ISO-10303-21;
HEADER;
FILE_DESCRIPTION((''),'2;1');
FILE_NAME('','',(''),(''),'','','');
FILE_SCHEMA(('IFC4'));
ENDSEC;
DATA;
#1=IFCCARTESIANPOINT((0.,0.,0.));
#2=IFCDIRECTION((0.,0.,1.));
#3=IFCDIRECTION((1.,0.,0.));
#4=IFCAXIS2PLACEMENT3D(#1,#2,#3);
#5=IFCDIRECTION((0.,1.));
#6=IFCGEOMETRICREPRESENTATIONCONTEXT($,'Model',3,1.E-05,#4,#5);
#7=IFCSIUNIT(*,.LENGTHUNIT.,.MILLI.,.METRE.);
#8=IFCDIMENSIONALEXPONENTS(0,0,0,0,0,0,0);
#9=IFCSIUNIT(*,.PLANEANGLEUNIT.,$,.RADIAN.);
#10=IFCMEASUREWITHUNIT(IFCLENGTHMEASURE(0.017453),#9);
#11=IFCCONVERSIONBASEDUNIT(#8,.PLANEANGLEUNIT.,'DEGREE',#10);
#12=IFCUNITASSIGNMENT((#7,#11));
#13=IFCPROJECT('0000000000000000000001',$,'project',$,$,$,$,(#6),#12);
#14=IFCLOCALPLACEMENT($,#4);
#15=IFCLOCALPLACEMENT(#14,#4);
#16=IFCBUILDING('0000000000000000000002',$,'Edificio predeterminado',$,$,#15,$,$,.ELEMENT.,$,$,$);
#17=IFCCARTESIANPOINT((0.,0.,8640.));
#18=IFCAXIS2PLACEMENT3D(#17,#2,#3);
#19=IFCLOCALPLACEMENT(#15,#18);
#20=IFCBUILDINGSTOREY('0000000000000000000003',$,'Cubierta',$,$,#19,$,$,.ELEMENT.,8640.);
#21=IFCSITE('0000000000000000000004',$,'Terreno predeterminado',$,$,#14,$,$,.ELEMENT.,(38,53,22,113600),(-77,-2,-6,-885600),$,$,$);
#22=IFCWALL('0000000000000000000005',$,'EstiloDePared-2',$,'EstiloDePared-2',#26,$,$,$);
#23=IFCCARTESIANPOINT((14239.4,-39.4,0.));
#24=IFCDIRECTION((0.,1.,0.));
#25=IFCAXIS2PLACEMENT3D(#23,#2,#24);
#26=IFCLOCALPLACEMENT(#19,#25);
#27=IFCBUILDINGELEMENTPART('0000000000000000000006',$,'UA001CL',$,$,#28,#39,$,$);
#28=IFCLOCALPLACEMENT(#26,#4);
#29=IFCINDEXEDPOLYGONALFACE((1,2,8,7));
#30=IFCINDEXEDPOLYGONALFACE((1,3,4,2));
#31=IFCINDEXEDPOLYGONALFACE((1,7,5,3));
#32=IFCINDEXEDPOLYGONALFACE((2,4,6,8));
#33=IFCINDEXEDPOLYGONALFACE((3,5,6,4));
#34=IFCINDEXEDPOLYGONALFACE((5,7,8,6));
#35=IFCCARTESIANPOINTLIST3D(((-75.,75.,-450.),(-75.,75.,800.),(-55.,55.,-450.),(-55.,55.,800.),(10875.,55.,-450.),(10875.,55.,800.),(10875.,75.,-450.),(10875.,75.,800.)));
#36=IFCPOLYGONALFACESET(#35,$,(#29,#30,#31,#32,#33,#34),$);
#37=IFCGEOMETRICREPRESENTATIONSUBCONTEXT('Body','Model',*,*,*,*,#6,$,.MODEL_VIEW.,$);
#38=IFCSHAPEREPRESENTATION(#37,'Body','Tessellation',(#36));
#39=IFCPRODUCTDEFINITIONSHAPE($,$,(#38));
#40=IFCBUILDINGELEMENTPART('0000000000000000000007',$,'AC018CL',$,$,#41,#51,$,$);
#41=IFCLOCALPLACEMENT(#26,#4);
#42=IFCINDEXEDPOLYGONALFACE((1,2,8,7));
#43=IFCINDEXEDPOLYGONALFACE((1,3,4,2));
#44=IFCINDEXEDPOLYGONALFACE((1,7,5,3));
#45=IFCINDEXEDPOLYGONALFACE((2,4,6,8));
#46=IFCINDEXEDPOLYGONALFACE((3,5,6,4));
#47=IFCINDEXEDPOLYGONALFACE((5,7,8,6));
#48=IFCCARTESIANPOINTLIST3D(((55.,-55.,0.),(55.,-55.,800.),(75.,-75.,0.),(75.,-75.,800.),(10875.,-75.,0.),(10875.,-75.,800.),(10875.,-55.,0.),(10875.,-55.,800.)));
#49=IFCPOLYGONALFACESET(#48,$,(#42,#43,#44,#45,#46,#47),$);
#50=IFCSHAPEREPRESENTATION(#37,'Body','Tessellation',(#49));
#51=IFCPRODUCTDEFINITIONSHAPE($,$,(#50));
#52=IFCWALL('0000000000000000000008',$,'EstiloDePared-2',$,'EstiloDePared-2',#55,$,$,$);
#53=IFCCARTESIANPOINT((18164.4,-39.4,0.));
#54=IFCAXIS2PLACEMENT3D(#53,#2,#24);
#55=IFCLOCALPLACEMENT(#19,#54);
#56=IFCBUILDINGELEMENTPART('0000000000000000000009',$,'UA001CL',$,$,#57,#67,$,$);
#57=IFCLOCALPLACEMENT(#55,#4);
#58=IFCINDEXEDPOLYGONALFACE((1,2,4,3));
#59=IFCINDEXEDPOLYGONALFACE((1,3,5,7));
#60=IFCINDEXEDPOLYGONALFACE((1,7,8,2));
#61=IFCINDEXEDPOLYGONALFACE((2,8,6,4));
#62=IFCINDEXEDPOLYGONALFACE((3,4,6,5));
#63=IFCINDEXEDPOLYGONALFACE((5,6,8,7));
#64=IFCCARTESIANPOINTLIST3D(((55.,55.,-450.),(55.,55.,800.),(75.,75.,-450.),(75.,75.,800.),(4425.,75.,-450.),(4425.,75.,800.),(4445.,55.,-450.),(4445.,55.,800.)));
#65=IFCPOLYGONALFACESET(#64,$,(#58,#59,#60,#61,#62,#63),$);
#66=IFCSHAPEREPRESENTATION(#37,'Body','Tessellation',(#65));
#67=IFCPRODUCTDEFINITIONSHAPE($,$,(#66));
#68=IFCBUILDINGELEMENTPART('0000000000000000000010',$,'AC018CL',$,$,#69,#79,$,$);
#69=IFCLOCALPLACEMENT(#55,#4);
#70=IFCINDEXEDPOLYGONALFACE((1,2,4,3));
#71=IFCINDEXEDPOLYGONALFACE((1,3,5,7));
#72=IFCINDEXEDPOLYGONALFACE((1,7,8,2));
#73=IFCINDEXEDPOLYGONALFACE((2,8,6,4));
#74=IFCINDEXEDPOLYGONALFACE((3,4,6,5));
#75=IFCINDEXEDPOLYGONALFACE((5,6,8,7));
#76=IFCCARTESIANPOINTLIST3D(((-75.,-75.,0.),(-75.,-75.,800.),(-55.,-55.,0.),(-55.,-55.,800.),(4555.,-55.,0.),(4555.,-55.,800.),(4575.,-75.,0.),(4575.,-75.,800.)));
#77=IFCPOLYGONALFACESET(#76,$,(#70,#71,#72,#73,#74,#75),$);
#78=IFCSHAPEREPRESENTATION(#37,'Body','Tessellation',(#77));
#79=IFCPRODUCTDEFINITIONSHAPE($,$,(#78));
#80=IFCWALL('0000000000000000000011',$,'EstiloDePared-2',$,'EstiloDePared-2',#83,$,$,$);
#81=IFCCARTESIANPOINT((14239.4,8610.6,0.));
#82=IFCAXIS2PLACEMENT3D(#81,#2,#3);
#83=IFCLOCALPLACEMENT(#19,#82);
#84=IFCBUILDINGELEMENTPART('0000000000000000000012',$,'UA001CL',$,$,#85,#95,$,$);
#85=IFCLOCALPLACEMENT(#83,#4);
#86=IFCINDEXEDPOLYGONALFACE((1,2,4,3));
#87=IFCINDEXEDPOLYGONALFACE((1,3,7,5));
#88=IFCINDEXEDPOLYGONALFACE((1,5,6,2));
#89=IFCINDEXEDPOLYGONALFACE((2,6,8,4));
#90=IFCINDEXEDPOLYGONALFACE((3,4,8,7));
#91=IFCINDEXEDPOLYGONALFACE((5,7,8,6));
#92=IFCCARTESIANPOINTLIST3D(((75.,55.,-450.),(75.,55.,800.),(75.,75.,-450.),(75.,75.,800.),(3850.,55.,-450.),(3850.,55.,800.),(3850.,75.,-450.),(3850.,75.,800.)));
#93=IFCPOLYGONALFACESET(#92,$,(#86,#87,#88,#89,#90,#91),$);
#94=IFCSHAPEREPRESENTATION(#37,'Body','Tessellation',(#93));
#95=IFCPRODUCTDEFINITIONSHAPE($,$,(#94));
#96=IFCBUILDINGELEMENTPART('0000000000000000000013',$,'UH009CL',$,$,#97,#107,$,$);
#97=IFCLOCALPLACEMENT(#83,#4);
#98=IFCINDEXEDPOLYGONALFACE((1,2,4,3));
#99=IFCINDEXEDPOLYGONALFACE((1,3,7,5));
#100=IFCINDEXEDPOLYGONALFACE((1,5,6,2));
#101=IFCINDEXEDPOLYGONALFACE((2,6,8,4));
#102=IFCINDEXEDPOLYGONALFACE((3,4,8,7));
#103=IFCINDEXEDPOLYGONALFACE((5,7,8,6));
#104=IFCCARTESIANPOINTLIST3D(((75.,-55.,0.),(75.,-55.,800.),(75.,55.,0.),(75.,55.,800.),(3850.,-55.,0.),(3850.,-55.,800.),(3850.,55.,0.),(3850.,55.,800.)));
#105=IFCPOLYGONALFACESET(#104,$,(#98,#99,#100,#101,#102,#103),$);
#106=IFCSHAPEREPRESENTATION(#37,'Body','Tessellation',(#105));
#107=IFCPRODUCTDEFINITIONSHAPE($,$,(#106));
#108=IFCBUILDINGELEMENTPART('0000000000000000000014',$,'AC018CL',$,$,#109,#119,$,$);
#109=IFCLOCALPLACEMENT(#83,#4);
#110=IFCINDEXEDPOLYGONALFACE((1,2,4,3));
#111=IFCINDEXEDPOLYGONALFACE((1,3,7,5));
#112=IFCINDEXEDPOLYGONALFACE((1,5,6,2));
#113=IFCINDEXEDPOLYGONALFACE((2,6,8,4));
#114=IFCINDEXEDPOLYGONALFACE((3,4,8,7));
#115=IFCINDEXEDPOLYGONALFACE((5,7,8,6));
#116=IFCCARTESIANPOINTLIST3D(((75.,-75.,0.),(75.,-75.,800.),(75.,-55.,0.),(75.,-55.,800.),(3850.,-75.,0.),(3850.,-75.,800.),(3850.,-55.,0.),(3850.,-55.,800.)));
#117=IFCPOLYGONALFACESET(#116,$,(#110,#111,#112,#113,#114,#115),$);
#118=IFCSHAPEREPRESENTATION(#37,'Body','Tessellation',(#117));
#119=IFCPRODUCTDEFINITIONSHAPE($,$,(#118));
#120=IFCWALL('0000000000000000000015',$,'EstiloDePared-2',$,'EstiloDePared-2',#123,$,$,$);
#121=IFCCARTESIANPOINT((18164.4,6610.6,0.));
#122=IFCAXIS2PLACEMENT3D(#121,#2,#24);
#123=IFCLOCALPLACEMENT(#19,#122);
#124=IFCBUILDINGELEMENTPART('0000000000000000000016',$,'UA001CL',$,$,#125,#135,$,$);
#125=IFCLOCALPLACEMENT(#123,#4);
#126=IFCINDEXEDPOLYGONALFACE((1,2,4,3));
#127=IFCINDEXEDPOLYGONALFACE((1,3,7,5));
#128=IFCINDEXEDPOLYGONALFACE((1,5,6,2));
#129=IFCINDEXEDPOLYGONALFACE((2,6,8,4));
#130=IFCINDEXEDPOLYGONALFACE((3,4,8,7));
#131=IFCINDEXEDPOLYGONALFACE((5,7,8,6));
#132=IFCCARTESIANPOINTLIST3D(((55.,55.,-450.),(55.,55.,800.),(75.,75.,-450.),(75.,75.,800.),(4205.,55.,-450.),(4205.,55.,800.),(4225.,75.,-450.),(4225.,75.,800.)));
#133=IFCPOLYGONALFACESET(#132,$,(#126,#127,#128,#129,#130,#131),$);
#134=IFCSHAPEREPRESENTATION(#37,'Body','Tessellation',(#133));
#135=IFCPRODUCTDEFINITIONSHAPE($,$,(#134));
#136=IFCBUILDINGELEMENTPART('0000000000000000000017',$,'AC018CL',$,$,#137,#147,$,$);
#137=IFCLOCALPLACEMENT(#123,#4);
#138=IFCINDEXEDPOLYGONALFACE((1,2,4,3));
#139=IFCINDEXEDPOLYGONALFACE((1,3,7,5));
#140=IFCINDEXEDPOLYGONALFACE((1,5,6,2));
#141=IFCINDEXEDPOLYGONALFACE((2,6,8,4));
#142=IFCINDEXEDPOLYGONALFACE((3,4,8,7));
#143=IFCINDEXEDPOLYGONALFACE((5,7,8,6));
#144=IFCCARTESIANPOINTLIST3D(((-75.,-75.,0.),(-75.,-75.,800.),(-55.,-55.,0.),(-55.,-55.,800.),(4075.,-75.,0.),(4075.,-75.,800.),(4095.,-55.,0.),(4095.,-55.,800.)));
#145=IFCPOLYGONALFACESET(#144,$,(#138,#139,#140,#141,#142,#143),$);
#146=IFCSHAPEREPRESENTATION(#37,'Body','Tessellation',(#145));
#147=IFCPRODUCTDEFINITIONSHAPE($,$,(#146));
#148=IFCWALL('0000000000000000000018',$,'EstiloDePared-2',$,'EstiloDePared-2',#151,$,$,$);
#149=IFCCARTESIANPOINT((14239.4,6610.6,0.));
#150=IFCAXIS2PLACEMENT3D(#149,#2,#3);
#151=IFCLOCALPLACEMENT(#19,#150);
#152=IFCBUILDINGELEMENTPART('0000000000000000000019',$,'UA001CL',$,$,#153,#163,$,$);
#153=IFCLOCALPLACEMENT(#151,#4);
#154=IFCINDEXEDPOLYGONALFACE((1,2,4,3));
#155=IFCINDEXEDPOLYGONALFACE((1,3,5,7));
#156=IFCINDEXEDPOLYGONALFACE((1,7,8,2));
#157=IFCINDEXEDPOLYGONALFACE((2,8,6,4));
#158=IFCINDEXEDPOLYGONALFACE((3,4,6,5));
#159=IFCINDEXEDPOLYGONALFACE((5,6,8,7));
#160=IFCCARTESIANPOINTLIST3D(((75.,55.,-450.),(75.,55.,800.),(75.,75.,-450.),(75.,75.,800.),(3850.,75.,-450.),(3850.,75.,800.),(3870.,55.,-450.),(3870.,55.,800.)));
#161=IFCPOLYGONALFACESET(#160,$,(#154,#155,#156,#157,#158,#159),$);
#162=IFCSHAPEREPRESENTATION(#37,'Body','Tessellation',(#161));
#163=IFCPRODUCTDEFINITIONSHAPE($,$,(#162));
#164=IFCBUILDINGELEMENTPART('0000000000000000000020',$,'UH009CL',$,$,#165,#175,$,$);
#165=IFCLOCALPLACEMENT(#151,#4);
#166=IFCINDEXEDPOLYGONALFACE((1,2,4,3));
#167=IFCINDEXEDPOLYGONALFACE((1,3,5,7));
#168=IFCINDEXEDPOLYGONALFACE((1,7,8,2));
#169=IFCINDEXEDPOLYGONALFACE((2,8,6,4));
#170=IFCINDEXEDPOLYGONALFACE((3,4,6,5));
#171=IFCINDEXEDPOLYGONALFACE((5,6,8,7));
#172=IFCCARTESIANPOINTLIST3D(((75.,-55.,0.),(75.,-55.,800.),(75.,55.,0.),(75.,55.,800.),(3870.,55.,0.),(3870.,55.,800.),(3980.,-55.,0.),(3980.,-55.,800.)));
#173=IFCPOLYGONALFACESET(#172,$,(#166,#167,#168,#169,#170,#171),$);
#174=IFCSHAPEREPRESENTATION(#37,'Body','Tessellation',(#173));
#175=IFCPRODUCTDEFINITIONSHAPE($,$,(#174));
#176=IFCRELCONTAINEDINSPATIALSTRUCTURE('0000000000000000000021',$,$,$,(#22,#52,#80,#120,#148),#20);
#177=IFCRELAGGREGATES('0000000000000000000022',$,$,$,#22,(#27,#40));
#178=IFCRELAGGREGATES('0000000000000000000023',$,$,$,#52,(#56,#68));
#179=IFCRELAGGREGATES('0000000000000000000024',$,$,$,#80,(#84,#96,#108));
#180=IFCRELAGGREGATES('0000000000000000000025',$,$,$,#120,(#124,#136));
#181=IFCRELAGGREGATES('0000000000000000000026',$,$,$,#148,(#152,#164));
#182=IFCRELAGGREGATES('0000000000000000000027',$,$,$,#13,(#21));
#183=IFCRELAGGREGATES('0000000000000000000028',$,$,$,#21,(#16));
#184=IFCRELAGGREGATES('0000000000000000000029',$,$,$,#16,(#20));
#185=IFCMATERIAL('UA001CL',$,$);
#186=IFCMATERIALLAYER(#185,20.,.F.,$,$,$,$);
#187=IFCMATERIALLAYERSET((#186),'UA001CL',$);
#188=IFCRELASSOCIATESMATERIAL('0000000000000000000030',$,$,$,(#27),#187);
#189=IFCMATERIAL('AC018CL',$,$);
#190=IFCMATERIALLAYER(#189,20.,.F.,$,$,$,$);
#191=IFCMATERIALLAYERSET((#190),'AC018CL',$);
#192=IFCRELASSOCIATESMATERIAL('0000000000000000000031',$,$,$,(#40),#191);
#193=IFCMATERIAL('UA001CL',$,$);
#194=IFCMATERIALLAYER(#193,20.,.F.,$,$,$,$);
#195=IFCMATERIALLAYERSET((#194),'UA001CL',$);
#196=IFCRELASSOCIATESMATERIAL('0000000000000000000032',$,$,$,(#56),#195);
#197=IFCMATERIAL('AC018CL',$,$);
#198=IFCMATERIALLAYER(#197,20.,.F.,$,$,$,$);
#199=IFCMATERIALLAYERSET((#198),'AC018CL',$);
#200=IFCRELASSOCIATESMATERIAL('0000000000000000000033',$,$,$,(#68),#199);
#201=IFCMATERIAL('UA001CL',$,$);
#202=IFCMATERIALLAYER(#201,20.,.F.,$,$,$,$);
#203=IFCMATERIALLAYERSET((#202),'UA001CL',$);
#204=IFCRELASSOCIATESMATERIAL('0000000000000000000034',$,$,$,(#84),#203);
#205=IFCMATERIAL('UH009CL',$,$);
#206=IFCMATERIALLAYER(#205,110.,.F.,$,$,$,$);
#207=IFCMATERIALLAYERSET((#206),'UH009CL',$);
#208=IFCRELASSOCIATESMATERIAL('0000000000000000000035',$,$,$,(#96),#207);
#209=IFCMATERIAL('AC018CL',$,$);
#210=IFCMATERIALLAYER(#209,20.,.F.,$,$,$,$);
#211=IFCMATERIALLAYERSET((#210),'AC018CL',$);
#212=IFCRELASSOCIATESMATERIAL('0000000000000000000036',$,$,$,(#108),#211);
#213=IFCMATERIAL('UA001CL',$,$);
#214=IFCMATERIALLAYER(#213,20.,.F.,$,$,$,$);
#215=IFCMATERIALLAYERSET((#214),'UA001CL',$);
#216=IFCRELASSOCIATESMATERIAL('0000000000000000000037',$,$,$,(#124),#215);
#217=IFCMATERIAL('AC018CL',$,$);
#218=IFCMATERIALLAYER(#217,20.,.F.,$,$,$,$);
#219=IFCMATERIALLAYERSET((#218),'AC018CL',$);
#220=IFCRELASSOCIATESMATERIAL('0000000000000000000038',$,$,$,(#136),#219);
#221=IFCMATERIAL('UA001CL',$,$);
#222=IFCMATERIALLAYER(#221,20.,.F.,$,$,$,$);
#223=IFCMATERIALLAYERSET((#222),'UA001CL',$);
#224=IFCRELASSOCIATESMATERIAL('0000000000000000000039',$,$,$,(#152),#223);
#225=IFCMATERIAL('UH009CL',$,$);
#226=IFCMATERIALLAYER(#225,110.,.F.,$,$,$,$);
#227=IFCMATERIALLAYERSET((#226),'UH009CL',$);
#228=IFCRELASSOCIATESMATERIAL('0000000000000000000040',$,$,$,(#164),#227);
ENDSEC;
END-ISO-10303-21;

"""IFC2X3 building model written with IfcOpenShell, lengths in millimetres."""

from ifc_helpers import new_model, entity, si_unit, converted_unit, direction, frame, origin_with_axes, place, context, subcontext, project, spatial, polyline, outline, extrude, material, layer, layer_set, layer_usage, element, aggregate, save


model = new_model("IFC2X3")

# Units and contexts
model_context = context("Model", 3, precision=1e-05, world=origin_with_axes(), true_north=direction((0.0, 1.0)))
body_context = subcontext(model_context, "Body", "Model", "MODEL_VIEW")
ifc_project = project(units=[si_unit("LENGTHUNIT", "METRE", prefix="MILLI"), converted_unit("PLANEANGLEUNIT", "DEGREE", entity("IfcLengthMeasure", 0.017453), si_unit("PLANEANGLEUNIT", "RADIAN"), dimensions=[0, 0, 0, 0, 0, 0, 0])], contexts=[model_context])

# Site, building, storey
site_placement = place(None, origin_with_axes())
site = spatial("IfcSite", under=ifc_project, at=site_placement, Name="Terreno predeterminado", CompositionType="ELEMENT", RefLatitude=(38, 53, 22, 113600), RefLongitude=(-77, -2, -6, -885600))
building_placement = place(site_placement, origin_with_axes())
building = spatial("IfcBuilding", under=site, at=building_placement, Name="Edificio predeterminado", CompositionType="ELEMENT")
storey_placement = place(building_placement, frame((0.0, 0.0, 8640.0), z_axis=(0.0, 0.0, 1.0), x_axis=(1.0, 0.0, 0.0)))
storey = spatial("IfcBuildingStorey", under=building, at=storey_placement, Name="Cubierta", CompositionType="ELEMENT", Elevation=8640.0)

# Walls, building element parts
wall_1_placement = place(storey_placement, frame((14239.4, -39.4, 0.0), z_axis=(0.0, 0.0, 1.0), x_axis=(0.0, 1.0, 0.0)))
wall_1 = element("IfcWall", 1, at=wall_1_placement, inside=storey, Name="EstiloDePared-2", ObjectType="EstiloDePared-2")
ifc_material_1 = material(Name="UA001CL")
ifc_layer_1 = layer(ifc_material_1, 20.0, ventilated=False)
ifc_layer_set_1 = layer_set([ifc_layer_1], Name="UA001CL")
ifc_layer_usage_1 = layer_usage(ifc_layer_set_1, "AXIS2", "NEGATIVE", -75.0)
building_element_part_1_placement = place(wall_1_placement, origin_with_axes())
building_element_part_1 = element("IfcBuildingElementPart", 2, at=building_element_part_1_placement, material=ifc_layer_usage_1, Name="UA001CL", context=body_context, shape_type="SweptSolid", body=[
    extrude(outline(polyline([(10875.0, 75.0), (10875.0, 55.0), (-55.0, 55.0), (-75.0, 75.0), (10875.0, 75.0)])), frame((0.0, 0.0, -450.0), z_axis=(0.0, 0.0, 1.0), x_axis=(1.0, 0.0, 0.0)), (0.0, 0.0, 1.0), 1250.0),
])
ifc_material_2 = material(Name="AC018CL")
ifc_layer_2 = layer(ifc_material_2, 20.0, ventilated=False)
ifc_layer_set_2 = layer_set([ifc_layer_2], Name="AC018CL")
ifc_layer_usage_2 = layer_usage(ifc_layer_set_2, "AXIS2", "NEGATIVE", 55.0)
building_element_part_2_placement = place(wall_1_placement, origin_with_axes())
building_element_part_2 = element("IfcBuildingElementPart", 3, at=building_element_part_2_placement, material=ifc_layer_usage_2, Name="AC018CL", context=body_context, shape_type="SweptSolid", body=[
    extrude(outline(polyline([(10875.0, -55.0), (10875.0, -75.0), (75.0, -75.0), (55.0, -55.0), (10875.0, -55.0)])), origin_with_axes(), (0.0, 0.0, 1.0), 800.0),
])
aggregate(wall_1, [building_element_part_1, building_element_part_2])
wall_2_placement = place(storey_placement, frame((18164.4, -39.4, 0.0), z_axis=(0.0, 0.0, 1.0), x_axis=(0.0, 1.0, 0.0)))
wall_2 = element("IfcWall", 4, at=wall_2_placement, inside=storey, Name="EstiloDePared-2", ObjectType="EstiloDePared-2")
ifc_material_3 = material(Name="UA001CL")
ifc_layer_3 = layer(ifc_material_3, 20.0, ventilated=False)
ifc_layer_set_3 = layer_set([ifc_layer_3], Name="UA001CL")
ifc_layer_usage_3 = layer_usage(ifc_layer_set_3, "AXIS2", "NEGATIVE", -75.0)
building_element_part_3_placement = place(wall_2_placement, origin_with_axes())
building_element_part_3 = element("IfcBuildingElementPart", 5, at=building_element_part_3_placement, material=ifc_layer_usage_3, Name="UA001CL", context=body_context, shape_type="SweptSolid", body=[
    extrude(outline(polyline([(4425.0, 75.0), (4445.0, 55.0), (55.0, 55.0), (75.0, 75.0), (4425.0, 75.0)])), frame((0.0, 0.0, -450.0), z_axis=(0.0, 0.0, 1.0), x_axis=(1.0, 0.0, 0.0)), (0.0, 0.0, 1.0), 1250.0),
])
ifc_material_4 = material(Name="AC018CL")
ifc_layer_4 = layer(ifc_material_4, 20.0, ventilated=False)
ifc_layer_set_4 = layer_set([ifc_layer_4], Name="AC018CL")
ifc_layer_usage_4 = layer_usage(ifc_layer_set_4, "AXIS2", "NEGATIVE", 55.0)
building_element_part_4_placement = place(wall_2_placement, origin_with_axes())
building_element_part_4 = element("IfcBuildingElementPart", 6, at=building_element_part_4_placement, material=ifc_layer_usage_4, Name="AC018CL", context=body_context, shape_type="SweptSolid", body=[
    extrude(outline(polyline([(4555.0, -55.0), (4575.0, -75.0), (-75.0, -75.0), (-55.0, -55.0), (4555.0, -55.0)])), origin_with_axes(), (0.0, 0.0, 1.0), 800.0),
])
aggregate(wall_2, [building_element_part_3, building_element_part_4])
wall_3_placement = place(storey_placement, frame((14239.4, 8610.6, 0.0), z_axis=(0.0, 0.0, 1.0), x_axis=(1.0, 0.0, 0.0)))
wall_3 = element("IfcWall", 7, at=wall_3_placement, inside=storey, Name="EstiloDePared-2", ObjectType="EstiloDePared-2")
ifc_material_5 = material(Name="UA001CL")
ifc_layer_5 = layer(ifc_material_5, 20.0, ventilated=False)
ifc_layer_set_5 = layer_set([ifc_layer_5], Name="UA001CL")
ifc_layer_usage_5 = layer_usage(ifc_layer_set_5, "AXIS2", "NEGATIVE", -75.0)
building_element_part_5_placement = place(wall_3_placement, origin_with_axes())
building_element_part_5 = element("IfcBuildingElementPart", 8, at=building_element_part_5_placement, material=ifc_layer_usage_5, Name="UA001CL", context=body_context, shape_type="SweptSolid", body=[
    extrude(outline(polyline([(3850.0, 75.0), (3850.0, 55.0), (75.0, 55.0), (75.0, 75.0), (3850.0, 75.0)])), frame((0.0, 0.0, -450.0), z_axis=(0.0, 0.0, 1.0), x_axis=(1.0, 0.0, 0.0)), (0.0, 0.0, 1.0), 1250.0),
])
ifc_material_6 = material(Name="UH009CL")
ifc_layer_6 = layer(ifc_material_6, 110.0, ventilated=False)
ifc_layer_set_6 = layer_set([ifc_layer_6], Name="UH009CL")
ifc_layer_usage_6 = layer_usage(ifc_layer_set_6, "AXIS2", "NEGATIVE", -55.0)
building_element_part_6_placement = place(wall_3_placement, origin_with_axes())
building_element_part_6 = element("IfcBuildingElementPart", 9, at=building_element_part_6_placement, material=ifc_layer_usage_6, Name="UH009CL", context=body_context, shape_type="SweptSolid", body=[
    extrude(outline(polyline([(3850.0, 55.0), (3850.0, -55.0), (75.0, -55.0), (75.0, 55.0), (3850.0, 55.0)])), origin_with_axes(), (0.0, 0.0, 1.0), 800.0),
])
ifc_material_7 = material(Name="AC018CL")
ifc_layer_7 = layer(ifc_material_7, 20.0, ventilated=False)
ifc_layer_set_7 = layer_set([ifc_layer_7], Name="AC018CL")
ifc_layer_usage_7 = layer_usage(ifc_layer_set_7, "AXIS2", "NEGATIVE", 55.0)
building_element_part_7_placement = place(wall_3_placement, origin_with_axes())
building_element_part_7 = element("IfcBuildingElementPart", 10, at=building_element_part_7_placement, material=ifc_layer_usage_7, Name="AC018CL", context=body_context, shape_type="SweptSolid", body=[
    extrude(outline(polyline([(3850.0, -55.0), (3850.0, -75.0), (75.0, -75.0), (75.0, -55.0), (3850.0, -55.0)])), origin_with_axes(), (0.0, 0.0, 1.0), 800.0),
])
aggregate(wall_3, [building_element_part_5, building_element_part_6, building_element_part_7])
wall_4_placement = place(storey_placement, frame((18164.4, 6610.6, 0.0), z_axis=(0.0, 0.0, 1.0), x_axis=(0.0, 1.0, 0.0)))
wall_4 = element("IfcWall", 11, at=wall_4_placement, inside=storey, Name="EstiloDePared-2", ObjectType="EstiloDePared-2")
ifc_material_8 = material(Name="UA001CL")
ifc_layer_8 = layer(ifc_material_8, 20.0, ventilated=False)
ifc_layer_set_8 = layer_set([ifc_layer_8], Name="UA001CL")
ifc_layer_usage_8 = layer_usage(ifc_layer_set_8, "AXIS2", "NEGATIVE", -75.0)
building_element_part_8_placement = place(wall_4_placement, origin_with_axes())
building_element_part_8 = element("IfcBuildingElementPart", 12, at=building_element_part_8_placement, material=ifc_layer_usage_8, Name="UA001CL", context=body_context, shape_type="SweptSolid", body=[
    extrude(outline(polyline([(4225.0, 75.0), (4205.0, 55.0), (55.0, 55.0), (75.0, 75.0), (4225.0, 75.0)])), frame((0.0, 0.0, -450.0), z_axis=(0.0, 0.0, 1.0), x_axis=(1.0, 0.0, 0.0)), (0.0, 0.0, 1.0), 1250.0),
])
ifc_material_9 = material(Name="AC018CL")
ifc_layer_9 = layer(ifc_material_9, 20.0, ventilated=False)
ifc_layer_set_9 = layer_set([ifc_layer_9], Name="AC018CL")
ifc_layer_usage_9 = layer_usage(ifc_layer_set_9, "AXIS2", "NEGATIVE", 55.0)
building_element_part_9_placement = place(wall_4_placement, origin_with_axes())
building_element_part_9 = element("IfcBuildingElementPart", 13, at=building_element_part_9_placement, material=ifc_layer_usage_9, Name="AC018CL", context=body_context, shape_type="SweptSolid", body=[
    extrude(outline(polyline([(4095.0, -55.0), (4075.0, -75.0), (-75.0, -75.0), (-55.0, -55.0), (4095.0, -55.0)])), origin_with_axes(), (0.0, 0.0, 1.0), 800.0),
])
aggregate(wall_4, [building_element_part_8, building_element_part_9])
wall_5_placement = place(storey_placement, frame((14239.4, 6610.6, 0.0), z_axis=(0.0, 0.0, 1.0), x_axis=(1.0, 0.0, 0.0)))
wall_5 = element("IfcWall", 14, at=wall_5_placement, inside=storey, Name="EstiloDePared-2", ObjectType="EstiloDePared-2")
ifc_material_10 = material(Name="UA001CL")
ifc_layer_10 = layer(ifc_material_10, 20.0, ventilated=False)
ifc_layer_set_10 = layer_set([ifc_layer_10], Name="UA001CL")
ifc_layer_usage_10 = layer_usage(ifc_layer_set_10, "AXIS2", "NEGATIVE", -75.0)
building_element_part_10_placement = place(wall_5_placement, origin_with_axes())
building_element_part_10 = element("IfcBuildingElementPart", 15, at=building_element_part_10_placement, material=ifc_layer_usage_10, Name="UA001CL", context=body_context, shape_type="SweptSolid", body=[
    extrude(outline(polyline([(3850.0, 75.0), (3870.0, 55.0), (75.0, 55.0), (75.0, 75.0), (3850.0, 75.0)])), frame((0.0, 0.0, -450.0), z_axis=(0.0, 0.0, 1.0), x_axis=(1.0, 0.0, 0.0)), (0.0, 0.0, 1.0), 1250.0),
])
ifc_material_11 = material(Name="UH009CL")
ifc_layer_11 = layer(ifc_material_11, 110.0, ventilated=False)
ifc_layer_set_11 = layer_set([ifc_layer_11], Name="UH009CL")
ifc_layer_usage_11 = layer_usage(ifc_layer_set_11, "AXIS2", "NEGATIVE", -55.0)
building_element_part_11_placement = place(wall_5_placement, origin_with_axes())
building_element_part_11 = element("IfcBuildingElementPart", 16, at=building_element_part_11_placement, material=ifc_layer_usage_11, Name="UH009CL", context=body_context, shape_type="SweptSolid", body=[
    extrude(outline(polyline([(3870.0, 55.0), (3980.0, -55.0), (75.0, -55.0), (75.0, 55.0), (3870.0, 55.0)])), origin_with_axes(), (0.0, 0.0, 1.0), 800.0),
])
aggregate(wall_5, [building_element_part_10, building_element_part_11])

save(model, "model.ifc")
